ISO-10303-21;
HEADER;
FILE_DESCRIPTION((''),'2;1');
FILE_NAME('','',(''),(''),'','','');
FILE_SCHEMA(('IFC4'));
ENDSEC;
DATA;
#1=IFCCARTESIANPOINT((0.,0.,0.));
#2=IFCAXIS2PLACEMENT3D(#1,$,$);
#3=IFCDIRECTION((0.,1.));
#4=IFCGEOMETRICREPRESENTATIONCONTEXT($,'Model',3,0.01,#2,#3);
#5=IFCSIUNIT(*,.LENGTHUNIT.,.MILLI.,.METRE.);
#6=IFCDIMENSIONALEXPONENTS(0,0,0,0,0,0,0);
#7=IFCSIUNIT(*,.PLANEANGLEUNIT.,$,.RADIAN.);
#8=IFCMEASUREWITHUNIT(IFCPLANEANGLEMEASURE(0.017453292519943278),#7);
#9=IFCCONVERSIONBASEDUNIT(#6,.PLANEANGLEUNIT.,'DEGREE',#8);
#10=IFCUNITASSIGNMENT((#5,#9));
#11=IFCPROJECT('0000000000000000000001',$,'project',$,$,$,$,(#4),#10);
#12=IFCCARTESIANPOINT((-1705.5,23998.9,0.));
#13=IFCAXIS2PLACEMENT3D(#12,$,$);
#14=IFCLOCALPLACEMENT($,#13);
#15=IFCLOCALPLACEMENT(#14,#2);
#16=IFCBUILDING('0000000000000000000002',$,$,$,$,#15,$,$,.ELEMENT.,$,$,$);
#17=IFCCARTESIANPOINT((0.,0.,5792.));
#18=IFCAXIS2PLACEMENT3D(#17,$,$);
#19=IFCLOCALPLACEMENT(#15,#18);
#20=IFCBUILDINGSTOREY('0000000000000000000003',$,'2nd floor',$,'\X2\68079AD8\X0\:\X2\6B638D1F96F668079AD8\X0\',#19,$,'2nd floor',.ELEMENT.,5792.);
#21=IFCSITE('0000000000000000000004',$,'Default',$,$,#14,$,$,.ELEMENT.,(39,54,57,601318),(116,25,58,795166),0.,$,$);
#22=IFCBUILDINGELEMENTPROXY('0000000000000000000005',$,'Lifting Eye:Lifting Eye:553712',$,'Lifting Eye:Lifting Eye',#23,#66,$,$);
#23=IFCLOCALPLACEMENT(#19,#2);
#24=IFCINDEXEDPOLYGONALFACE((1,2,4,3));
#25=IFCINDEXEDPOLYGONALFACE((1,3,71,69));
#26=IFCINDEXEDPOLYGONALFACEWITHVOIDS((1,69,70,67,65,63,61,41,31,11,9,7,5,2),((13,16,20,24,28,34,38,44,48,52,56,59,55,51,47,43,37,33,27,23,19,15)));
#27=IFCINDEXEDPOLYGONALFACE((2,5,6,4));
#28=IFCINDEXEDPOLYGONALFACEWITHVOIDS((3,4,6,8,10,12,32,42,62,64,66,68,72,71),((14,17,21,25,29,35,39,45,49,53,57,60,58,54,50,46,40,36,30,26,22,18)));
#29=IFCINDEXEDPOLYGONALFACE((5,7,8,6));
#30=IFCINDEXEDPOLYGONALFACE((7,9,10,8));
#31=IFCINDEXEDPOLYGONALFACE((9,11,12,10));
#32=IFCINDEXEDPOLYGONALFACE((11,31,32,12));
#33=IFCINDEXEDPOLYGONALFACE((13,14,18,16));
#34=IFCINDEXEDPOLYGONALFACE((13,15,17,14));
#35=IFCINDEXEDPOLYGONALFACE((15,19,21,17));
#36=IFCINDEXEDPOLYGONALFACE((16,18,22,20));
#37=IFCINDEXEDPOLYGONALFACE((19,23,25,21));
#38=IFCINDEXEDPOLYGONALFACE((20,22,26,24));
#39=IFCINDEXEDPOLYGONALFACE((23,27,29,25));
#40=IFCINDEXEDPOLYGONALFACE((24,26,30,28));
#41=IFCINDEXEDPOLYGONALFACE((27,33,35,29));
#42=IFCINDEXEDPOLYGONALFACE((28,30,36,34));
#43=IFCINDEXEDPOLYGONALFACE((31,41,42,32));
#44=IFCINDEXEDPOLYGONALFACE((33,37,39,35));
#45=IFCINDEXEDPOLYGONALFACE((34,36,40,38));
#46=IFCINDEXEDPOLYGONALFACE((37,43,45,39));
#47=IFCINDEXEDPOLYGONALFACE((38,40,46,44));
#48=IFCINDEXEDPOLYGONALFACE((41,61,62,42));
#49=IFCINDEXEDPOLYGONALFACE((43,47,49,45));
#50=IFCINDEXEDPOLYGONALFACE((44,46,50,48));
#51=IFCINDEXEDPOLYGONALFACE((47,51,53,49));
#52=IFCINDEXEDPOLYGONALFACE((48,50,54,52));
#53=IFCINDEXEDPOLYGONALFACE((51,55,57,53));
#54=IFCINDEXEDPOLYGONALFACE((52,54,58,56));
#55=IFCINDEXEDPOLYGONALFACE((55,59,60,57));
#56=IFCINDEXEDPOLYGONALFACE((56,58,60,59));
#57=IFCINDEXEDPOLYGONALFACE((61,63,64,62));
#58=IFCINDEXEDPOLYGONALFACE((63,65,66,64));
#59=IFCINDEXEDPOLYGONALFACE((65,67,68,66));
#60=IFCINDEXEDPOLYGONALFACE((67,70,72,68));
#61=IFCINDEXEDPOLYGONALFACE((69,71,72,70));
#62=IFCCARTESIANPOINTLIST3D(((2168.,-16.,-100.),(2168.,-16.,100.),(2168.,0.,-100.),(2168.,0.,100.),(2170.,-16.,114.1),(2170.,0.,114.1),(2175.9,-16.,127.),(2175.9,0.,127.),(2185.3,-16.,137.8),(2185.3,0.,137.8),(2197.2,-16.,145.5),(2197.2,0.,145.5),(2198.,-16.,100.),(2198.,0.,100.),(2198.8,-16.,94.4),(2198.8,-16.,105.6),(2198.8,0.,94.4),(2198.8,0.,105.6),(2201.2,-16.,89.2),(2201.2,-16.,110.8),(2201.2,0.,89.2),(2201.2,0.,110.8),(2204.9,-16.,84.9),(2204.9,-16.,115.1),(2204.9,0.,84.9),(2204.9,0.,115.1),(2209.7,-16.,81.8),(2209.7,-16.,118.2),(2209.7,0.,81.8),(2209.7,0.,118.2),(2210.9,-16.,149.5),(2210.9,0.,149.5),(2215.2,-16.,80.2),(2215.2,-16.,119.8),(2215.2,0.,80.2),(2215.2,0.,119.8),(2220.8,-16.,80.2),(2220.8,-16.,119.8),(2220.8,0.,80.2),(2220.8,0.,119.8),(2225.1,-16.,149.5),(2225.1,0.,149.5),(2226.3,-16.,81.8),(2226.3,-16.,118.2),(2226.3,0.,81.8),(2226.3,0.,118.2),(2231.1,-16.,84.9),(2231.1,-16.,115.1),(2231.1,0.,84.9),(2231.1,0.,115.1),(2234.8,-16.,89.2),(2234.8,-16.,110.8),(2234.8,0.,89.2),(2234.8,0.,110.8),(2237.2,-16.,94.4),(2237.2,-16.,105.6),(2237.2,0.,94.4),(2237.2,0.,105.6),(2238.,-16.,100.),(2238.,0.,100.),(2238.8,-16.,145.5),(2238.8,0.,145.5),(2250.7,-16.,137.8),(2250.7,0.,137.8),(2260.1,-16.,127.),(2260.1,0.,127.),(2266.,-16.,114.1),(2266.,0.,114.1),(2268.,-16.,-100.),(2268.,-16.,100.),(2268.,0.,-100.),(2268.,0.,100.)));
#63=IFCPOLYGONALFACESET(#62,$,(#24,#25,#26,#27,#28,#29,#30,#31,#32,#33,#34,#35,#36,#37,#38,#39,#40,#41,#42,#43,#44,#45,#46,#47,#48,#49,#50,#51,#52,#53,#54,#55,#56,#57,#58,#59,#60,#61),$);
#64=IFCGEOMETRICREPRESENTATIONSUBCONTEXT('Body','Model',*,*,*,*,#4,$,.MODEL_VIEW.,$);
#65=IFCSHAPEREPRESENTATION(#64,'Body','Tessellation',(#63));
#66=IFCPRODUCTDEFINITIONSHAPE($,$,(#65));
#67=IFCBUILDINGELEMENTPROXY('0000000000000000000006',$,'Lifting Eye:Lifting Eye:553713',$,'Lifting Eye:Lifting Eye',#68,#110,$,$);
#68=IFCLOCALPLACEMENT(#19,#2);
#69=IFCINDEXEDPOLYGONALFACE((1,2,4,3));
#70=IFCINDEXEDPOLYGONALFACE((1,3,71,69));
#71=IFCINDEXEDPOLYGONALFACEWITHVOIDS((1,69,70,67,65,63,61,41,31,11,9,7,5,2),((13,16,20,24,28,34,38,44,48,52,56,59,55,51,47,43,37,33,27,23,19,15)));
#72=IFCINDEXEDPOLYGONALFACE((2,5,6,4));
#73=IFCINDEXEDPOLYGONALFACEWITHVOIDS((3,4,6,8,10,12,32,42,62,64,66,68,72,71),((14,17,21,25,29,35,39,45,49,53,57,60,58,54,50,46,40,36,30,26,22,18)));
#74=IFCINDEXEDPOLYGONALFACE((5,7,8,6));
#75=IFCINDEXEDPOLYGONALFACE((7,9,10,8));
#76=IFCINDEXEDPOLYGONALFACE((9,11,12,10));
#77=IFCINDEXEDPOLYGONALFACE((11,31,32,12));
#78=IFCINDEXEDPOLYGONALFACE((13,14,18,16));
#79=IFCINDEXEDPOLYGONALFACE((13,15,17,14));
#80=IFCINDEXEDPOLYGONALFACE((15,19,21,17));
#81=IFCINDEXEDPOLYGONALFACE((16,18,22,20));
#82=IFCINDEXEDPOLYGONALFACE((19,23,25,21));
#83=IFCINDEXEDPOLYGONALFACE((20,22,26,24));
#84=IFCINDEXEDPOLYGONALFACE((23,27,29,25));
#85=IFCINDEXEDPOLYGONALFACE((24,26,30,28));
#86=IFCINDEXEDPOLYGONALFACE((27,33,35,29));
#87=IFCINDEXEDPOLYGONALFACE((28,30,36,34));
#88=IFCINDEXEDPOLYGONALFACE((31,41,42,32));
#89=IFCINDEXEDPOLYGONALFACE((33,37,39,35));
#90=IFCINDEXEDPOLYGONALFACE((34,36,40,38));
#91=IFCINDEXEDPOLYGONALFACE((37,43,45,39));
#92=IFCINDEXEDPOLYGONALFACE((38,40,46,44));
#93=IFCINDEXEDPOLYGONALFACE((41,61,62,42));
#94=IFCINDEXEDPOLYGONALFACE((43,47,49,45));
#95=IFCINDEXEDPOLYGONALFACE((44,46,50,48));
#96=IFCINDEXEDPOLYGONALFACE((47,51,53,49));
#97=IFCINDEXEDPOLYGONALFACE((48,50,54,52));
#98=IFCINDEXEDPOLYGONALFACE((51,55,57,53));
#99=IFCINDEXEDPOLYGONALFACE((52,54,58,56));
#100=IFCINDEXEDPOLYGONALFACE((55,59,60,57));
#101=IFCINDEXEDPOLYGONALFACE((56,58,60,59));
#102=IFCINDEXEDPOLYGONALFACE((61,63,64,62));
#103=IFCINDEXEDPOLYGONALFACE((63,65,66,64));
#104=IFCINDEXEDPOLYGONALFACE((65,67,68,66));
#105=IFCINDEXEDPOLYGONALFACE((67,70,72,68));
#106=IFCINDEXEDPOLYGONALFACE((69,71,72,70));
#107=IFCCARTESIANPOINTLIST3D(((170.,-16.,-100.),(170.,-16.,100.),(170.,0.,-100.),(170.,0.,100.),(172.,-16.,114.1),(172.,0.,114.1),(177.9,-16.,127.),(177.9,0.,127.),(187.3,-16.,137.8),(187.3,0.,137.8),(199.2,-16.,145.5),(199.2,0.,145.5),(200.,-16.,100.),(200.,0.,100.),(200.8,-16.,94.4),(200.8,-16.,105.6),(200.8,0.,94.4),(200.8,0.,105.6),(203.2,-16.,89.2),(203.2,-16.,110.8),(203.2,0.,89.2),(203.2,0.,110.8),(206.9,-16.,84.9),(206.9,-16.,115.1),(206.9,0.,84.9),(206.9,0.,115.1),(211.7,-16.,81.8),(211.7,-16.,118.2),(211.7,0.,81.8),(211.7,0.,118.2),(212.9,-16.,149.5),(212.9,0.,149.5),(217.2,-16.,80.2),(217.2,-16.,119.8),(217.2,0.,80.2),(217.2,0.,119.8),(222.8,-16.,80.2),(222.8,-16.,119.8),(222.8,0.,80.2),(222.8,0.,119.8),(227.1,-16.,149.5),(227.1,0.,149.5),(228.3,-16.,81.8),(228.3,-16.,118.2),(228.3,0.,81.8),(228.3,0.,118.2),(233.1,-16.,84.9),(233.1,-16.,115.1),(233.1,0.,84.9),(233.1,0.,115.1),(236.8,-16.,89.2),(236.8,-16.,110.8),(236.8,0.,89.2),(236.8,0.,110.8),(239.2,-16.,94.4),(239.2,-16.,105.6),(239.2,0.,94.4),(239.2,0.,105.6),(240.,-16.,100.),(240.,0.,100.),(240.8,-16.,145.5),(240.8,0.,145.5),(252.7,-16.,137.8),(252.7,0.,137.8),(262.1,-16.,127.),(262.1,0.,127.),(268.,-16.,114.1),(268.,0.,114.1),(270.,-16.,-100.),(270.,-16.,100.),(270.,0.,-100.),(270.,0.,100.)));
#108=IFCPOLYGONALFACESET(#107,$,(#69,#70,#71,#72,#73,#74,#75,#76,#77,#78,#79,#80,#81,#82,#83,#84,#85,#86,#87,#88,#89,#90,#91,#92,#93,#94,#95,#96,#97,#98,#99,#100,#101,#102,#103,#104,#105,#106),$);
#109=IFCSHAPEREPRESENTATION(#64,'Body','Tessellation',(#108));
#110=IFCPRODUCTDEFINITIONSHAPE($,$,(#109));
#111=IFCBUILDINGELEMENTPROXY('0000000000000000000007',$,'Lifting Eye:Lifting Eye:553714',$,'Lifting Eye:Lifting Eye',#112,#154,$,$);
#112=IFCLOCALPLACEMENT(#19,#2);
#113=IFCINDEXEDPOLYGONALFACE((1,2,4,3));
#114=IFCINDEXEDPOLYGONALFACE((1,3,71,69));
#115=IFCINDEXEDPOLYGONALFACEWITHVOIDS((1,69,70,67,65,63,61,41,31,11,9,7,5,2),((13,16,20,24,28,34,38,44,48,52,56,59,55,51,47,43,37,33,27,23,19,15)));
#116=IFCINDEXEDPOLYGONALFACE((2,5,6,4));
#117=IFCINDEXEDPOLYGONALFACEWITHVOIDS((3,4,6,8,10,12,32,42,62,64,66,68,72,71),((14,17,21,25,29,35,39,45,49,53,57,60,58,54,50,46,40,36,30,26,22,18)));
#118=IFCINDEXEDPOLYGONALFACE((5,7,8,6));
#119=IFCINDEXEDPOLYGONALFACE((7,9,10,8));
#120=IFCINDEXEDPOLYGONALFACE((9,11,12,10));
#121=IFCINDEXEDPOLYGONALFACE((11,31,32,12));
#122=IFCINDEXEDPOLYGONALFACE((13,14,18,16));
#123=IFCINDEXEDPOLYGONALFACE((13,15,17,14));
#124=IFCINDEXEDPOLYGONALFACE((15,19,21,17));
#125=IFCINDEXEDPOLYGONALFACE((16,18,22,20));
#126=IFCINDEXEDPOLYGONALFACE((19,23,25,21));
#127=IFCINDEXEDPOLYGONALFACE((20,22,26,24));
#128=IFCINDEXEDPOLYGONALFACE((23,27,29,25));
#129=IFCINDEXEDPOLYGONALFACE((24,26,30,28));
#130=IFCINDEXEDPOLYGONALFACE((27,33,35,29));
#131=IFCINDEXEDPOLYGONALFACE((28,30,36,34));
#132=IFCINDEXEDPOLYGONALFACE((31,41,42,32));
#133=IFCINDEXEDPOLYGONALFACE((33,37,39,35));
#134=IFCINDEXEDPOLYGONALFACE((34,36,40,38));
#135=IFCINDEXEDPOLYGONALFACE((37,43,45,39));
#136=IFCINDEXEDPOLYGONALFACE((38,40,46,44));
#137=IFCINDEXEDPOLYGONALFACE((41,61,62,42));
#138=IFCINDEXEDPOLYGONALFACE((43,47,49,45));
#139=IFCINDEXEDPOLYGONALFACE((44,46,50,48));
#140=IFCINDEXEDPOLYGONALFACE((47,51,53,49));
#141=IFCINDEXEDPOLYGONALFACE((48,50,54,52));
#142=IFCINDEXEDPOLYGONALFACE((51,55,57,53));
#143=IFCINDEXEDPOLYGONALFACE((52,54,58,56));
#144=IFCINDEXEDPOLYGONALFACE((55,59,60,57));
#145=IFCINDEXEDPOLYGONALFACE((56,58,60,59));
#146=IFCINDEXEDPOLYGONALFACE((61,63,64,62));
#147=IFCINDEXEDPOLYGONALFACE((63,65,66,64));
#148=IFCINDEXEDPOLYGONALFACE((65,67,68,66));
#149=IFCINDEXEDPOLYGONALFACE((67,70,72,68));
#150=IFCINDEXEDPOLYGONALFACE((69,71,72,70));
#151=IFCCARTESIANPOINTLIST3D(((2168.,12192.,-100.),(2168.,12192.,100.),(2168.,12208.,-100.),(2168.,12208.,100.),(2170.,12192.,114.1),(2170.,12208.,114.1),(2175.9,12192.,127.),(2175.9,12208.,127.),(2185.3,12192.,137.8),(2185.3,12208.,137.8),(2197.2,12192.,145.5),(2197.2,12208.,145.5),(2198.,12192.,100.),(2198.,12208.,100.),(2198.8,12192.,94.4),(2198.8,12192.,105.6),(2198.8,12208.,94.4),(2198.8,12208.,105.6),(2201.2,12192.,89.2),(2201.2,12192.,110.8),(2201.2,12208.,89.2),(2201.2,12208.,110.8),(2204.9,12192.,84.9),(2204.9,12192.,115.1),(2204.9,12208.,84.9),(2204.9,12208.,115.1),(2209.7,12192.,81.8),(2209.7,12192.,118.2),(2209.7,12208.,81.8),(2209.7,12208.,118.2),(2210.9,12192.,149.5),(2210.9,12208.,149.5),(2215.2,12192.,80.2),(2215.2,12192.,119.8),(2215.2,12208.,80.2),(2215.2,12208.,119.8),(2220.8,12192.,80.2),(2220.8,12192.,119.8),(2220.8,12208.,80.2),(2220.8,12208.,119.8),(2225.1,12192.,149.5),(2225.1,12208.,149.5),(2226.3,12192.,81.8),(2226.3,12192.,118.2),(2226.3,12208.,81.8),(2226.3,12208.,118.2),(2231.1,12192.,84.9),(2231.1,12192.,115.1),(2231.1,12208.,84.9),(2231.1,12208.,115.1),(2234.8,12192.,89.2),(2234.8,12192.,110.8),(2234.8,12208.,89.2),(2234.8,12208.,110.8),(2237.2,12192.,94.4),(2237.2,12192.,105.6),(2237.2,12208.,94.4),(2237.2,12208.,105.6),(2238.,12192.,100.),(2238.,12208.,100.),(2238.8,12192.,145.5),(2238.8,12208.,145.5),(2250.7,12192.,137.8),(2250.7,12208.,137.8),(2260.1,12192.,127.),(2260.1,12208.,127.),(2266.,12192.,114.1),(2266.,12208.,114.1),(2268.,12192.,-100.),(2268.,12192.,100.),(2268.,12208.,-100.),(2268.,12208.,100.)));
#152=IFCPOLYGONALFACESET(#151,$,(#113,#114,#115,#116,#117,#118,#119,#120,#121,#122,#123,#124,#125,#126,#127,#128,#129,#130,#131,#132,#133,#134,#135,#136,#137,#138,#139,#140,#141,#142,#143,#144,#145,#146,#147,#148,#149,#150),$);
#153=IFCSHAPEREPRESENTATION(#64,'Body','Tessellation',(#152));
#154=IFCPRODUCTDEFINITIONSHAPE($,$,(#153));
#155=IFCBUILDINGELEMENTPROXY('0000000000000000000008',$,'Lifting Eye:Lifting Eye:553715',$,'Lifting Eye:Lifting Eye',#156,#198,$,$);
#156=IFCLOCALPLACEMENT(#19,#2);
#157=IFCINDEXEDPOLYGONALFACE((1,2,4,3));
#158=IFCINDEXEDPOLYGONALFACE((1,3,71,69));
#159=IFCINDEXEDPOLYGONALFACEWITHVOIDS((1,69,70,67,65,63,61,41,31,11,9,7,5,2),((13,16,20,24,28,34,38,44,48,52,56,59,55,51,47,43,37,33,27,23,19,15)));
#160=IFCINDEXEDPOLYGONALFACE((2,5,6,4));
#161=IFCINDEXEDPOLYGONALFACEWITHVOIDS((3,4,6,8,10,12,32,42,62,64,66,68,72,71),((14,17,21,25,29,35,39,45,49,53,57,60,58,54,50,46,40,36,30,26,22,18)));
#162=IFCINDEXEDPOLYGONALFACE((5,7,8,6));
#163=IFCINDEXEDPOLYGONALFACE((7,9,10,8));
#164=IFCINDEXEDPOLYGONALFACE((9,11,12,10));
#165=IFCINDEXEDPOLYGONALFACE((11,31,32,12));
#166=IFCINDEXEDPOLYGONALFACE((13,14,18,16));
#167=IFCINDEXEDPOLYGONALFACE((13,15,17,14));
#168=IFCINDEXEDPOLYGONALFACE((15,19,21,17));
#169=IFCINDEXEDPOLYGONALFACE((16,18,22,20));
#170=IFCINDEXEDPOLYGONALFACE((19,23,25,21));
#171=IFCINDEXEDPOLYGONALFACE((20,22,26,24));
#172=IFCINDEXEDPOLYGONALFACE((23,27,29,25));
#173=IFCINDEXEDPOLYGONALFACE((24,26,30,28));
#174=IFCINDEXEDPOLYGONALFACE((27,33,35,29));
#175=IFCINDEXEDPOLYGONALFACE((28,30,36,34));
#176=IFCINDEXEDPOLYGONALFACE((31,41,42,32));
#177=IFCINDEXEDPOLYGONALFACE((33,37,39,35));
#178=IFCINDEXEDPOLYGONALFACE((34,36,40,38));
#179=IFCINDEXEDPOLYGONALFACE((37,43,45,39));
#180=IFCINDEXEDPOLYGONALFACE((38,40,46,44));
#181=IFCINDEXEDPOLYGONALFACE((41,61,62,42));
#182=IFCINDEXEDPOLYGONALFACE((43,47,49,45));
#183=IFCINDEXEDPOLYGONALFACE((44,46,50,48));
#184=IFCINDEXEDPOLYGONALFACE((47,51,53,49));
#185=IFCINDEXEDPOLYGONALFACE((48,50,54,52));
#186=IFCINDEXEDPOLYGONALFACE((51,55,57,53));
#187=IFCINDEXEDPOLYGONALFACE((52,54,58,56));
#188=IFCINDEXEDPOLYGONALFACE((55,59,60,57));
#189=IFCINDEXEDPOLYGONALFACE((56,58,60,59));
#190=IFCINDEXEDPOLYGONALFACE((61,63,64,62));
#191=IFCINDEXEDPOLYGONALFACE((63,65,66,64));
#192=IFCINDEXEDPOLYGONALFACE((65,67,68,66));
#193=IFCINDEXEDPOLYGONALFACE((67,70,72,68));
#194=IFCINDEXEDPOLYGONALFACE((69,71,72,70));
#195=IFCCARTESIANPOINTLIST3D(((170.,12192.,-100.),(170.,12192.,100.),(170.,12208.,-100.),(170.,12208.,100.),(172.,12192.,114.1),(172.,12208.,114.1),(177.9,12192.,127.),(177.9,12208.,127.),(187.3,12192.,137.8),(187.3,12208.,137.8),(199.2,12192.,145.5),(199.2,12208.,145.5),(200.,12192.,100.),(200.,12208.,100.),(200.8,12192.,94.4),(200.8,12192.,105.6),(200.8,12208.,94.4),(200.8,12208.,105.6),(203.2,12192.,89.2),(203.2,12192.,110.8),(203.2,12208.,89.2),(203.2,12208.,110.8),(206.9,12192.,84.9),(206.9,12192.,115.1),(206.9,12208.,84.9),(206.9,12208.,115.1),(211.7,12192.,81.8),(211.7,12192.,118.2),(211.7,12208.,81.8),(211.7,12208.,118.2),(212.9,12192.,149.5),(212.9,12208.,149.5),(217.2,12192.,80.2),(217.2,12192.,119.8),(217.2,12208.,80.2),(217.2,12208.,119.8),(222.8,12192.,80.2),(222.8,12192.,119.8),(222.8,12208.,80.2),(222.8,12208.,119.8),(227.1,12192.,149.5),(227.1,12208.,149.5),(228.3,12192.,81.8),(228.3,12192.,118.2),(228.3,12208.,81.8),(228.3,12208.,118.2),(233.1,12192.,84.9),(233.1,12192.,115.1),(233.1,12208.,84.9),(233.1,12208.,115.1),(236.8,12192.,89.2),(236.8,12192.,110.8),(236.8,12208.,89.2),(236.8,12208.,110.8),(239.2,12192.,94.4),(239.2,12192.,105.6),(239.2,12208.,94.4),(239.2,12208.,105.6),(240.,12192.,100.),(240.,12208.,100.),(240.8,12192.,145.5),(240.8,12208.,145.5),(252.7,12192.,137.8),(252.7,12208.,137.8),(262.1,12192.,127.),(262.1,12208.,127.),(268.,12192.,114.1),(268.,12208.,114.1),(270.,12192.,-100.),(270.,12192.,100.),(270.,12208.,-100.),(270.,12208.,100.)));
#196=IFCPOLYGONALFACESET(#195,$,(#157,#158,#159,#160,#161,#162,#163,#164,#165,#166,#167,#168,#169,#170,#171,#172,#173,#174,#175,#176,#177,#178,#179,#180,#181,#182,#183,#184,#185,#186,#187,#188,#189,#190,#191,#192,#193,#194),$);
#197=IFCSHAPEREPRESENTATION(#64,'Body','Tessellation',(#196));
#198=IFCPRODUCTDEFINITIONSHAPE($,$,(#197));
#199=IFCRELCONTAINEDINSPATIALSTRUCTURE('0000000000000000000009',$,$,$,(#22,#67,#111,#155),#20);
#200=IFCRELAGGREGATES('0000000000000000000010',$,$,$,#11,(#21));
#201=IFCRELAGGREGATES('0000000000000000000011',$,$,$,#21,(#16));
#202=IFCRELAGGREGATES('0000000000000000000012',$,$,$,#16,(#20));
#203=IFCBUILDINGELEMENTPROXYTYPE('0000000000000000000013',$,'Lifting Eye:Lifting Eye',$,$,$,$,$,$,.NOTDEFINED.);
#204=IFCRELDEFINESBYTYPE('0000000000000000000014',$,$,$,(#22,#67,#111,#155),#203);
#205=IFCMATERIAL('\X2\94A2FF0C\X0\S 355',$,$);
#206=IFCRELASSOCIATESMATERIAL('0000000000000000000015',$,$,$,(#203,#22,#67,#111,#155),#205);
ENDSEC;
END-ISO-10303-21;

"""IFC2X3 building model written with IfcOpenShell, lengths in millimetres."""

from ifc_helpers import new_model, entity, si_unit, converted_unit, direction, frame, frame_2d, origin, place, context, subcontext, project, spatial, polyline, circle_curve, parameter, trimmed, segment, composite_curve, outline, extrude, source, transform, mapped, material, type_object, type_shapes, element, save


model = new_model("IFC2X3")

# Units and contexts
model_context = context("Model", 3, precision=0.01, world=origin(), true_north=direction((0.0, 1.0)))
body_context = subcontext(model_context, "Body", "Model", "MODEL_VIEW")
ifc_project = project(units=[si_unit("LENGTHUNIT", "METRE", prefix="MILLI"), converted_unit("PLANEANGLEUNIT", "DEGREE", entity("IfcPlaneAngleMeasure", 0.017453292519943278), si_unit("PLANEANGLEUNIT", "RADIAN"), dimensions=[0, 0, 0, 0, 0, 0, 0])], contexts=[model_context])

# Site, building, storey
site_placement = place(None, frame((-1705.5, 23998.9, 0.0)))
site = spatial("IfcSite", under=ifc_project, at=site_placement, Name="Default", CompositionType="ELEMENT", RefLatitude=(39, 54, 57, 601318), RefLongitude=(116, 25, 58, 795166), RefElevation=0.0)
building_placement = place(site_placement, origin())
building = spatial("IfcBuilding", under=site, at=building_placement, CompositionType="ELEMENT")
storey_placement = place(building_placement, frame((0.0, 0.0, 5792.0)))
storey = spatial("IfcBuildingStorey", under=building, at=storey_placement, Name="2nd floor", ObjectType="标高:正负零标高", LongName="2nd floor", CompositionType="ELEMENT", Elevation=5792.0)

# Building element proxies
ifc_material_1 = material(Name="钢，S 355")
building_element_proxy_type_1 = type_object("IfcBuildingElementProxyType", Name="Lifting Eye:Lifting Eye", PredefinedType="NOTDEFINED", material=ifc_material_1)
shared_shape_1 = source(origin(), body_context, "Body", "SweptSolid", [
    extrude(outline(composite_curve([segment(polyline([(-100.0, -50.0), (100.0, -50.0)]), True, "CONTINUOUS"), segment(polyline([(100.0, -50.0), (100.0, 50.0)]), True, "CONTINUOUS"), segment(polyline([(100.0, 50.0), (-100.0, 50.0)]), True, "CONTINUOUS"), segment(trimmed(circle_curve(frame_2d((-100.0, 0.0), x_axis=(0.0, -1.0)), 50.0), [parameter(180.0)], [parameter(0.0)], True, "PARAMETER"), True, "CONTINUOUS")], self_intersect=False), holes=[composite_curve([segment(trimmed(circle_curve(frame_2d((-100.0, 0.0), x_axis=(0.0, -1.0)), 20.0), [parameter(180.0)], [parameter(360.0)], True, "PARAMETER"), False, "CONTINUOUS"), segment(trimmed(circle_curve(frame_2d((-100.0, 0.0), x_axis=(0.0, -1.0)), 20.0), [parameter(0.0)], [parameter(180.0)], True, "PARAMETER"), False, "CONTINUOUS")], self_intersect=False)]), frame((0.0, 17.0, -17.0), z_axis=(0.0, 1.0, 0.0), x_axis=(0.0, 0.0, -1.0)), (0.0, 0.0, 1.0), 16.0),
])
type_shapes(building_element_proxy_type_1, [shared_shape_1])
for number, where, name in (
    (1, (2218.0, -33.0, 17.0), "Lifting Eye:Lifting Eye:553712"),
    (2, (220.0, -33.0, 17.0), "Lifting Eye:Lifting Eye:553713"),
    (3, (2218.0, 12175.0, 17.0), "Lifting Eye:Lifting Eye:553714"),
    (4, (220.0, 12175.0, 17.0), "Lifting Eye:Lifting Eye:553715"),
):
    element("IfcBuildingElementProxy", number, at=place(storey_placement, frame(where)), inside=storey, type_object=building_element_proxy_type_1, material=ifc_material_1, Name=name, ObjectType="Lifting Eye:Lifting Eye", context=body_context, shape_type="MappedRepresentation", body=[
        mapped(shared_shape_1, transform((0.0, 0.0, 0.0), scale=1.0)),
    ])

save(model, "model.ifc")
